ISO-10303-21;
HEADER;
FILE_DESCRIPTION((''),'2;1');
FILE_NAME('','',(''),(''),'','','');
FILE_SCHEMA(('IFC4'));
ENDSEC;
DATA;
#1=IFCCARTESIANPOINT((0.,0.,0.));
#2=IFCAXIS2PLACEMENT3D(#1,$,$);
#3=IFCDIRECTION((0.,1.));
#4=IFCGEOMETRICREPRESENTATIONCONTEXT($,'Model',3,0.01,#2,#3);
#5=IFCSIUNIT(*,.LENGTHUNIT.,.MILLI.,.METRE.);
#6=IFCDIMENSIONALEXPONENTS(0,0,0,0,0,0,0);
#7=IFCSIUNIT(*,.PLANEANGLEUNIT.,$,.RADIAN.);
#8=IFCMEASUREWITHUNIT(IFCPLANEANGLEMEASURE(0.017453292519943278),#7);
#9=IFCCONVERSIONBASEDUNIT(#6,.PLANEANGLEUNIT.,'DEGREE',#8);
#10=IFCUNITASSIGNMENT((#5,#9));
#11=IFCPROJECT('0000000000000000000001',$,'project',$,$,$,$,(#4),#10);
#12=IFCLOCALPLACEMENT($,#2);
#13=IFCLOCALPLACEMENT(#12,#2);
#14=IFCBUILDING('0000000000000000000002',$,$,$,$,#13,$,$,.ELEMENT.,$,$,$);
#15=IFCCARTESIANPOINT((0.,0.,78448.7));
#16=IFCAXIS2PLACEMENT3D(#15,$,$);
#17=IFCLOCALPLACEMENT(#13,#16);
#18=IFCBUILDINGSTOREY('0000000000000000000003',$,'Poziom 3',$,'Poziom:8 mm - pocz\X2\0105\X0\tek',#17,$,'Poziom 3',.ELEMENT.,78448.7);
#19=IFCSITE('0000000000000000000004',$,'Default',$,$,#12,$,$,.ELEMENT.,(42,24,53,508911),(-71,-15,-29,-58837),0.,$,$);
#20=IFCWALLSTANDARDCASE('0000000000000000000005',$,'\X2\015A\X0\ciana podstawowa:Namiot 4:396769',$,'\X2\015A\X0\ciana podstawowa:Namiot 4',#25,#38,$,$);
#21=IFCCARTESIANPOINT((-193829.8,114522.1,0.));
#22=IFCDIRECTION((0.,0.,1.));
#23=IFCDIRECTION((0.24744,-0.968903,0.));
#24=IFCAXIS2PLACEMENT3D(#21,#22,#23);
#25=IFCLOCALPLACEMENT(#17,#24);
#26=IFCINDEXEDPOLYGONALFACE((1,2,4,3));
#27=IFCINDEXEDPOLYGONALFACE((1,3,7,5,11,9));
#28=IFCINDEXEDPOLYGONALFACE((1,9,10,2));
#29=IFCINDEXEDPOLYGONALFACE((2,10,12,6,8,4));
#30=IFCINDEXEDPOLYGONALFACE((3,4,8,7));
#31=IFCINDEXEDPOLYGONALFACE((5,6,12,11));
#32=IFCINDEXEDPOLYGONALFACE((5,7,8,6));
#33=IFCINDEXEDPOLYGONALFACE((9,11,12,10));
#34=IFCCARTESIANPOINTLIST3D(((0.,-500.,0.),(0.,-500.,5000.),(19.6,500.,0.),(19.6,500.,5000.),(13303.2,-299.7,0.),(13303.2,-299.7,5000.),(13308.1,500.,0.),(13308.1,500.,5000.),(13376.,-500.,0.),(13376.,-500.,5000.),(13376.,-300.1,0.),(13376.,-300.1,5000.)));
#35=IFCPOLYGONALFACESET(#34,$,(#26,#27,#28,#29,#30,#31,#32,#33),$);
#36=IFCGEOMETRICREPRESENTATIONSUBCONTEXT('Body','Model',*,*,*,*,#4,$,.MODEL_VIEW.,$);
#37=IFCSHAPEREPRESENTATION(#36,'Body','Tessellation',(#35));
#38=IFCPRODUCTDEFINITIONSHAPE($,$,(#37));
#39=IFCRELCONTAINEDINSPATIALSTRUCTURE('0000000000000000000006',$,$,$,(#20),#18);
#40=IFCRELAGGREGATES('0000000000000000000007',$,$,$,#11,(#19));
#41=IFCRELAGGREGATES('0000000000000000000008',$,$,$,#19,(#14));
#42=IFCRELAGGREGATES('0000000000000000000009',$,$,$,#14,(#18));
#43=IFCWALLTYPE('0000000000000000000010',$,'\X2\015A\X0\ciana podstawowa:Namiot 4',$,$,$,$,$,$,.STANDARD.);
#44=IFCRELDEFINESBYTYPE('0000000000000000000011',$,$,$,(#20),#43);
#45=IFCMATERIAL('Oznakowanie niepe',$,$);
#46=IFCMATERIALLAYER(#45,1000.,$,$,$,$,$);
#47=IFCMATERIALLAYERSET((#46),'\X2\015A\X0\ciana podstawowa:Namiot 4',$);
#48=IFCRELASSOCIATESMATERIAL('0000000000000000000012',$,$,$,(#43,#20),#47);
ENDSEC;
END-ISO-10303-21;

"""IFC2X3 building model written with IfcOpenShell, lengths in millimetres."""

from ifc_helpers import new_model, entity, si_unit, converted_unit, direction, frame, origin, place, context, subcontext, project, spatial, polyline, outline, extrude, clip, bounded_halfspace, material, layer, layer_set, layer_usage, type_object, element, save


model = new_model("IFC2X3")

# Units and contexts
model_context = context("Model", 3, precision=0.01, world=origin(), true_north=direction((0.0, 1.0)))
body_context = subcontext(model_context, "Body", "Model", "MODEL_VIEW")
ifc_project = project(units=[si_unit("LENGTHUNIT", "METRE", prefix="MILLI"), converted_unit("PLANEANGLEUNIT", "DEGREE", entity("IfcPlaneAngleMeasure", 0.017453292519943278), si_unit("PLANEANGLEUNIT", "RADIAN"), dimensions=[0, 0, 0, 0, 0, 0, 0])], contexts=[model_context])

# Site, building, storey
site_placement = place(None, origin())
site = spatial("IfcSite", under=ifc_project, at=site_placement, Name="Default", CompositionType="ELEMENT", RefLatitude=(42, 24, 53, 508911), RefLongitude=(-71, -15, -29, -58837), RefElevation=0.0)
building_placement = place(site_placement, origin())
building = spatial("IfcBuilding", under=site, at=building_placement, CompositionType="ELEMENT")
storey_placement = place(building_placement, frame((0.0, 0.0, 78448.7)))
storey = spatial("IfcBuildingStorey", under=building, at=storey_placement, Name="Poziom 3", ObjectType="Poziom:8 mm - początek", LongName="Poziom 3", CompositionType="ELEMENT", Elevation=78448.7)

# Wall
ifc_material_1 = material(Name="Oznakowanie niepe")
ifc_layer_1 = layer(ifc_material_1, 1000.0)
ifc_layer_set_1 = layer_set([ifc_layer_1], Name="Ściana podstawowa:Namiot 4")
wall_type_1 = type_object("IfcWallType", Name="Ściana podstawowa:Namiot 4", PredefinedType="STANDARD", material=ifc_layer_set_1)
ifc_layer_usage_1 = layer_usage(ifc_layer_set_1, "AXIS2", "NEGATIVE", 500.0)
wall_1_placement = place(storey_placement, frame((-193829.8, 114522.1, 0.0), z_axis=(0.0, 0.0, 1.0), x_axis=(0.24744, -0.968903, 0.0)))
element("IfcWallStandardCase", 1, at=wall_1_placement, inside=storey, type_object=wall_type_1, material=ifc_layer_usage_1, Name="Ściana podstawowa:Namiot 4:396769", ObjectType="Ściana podstawowa:Namiot 4", context=body_context, shape_type="Clipping", body=[
    clip(clip(extrude(outline(polyline([(13376.0, -500.0), (13376.0, -300.1), (13303.2, -299.7), (13308.1, 500.0), (19.6, 500.0), (0.0, -500.0), (13376.0, -500.0)])), origin(), (0.0, 0.0, 1.0), 5000.0), bounded_halfspace(frame((13303.2, -299.7, 0.0), z_axis=(-0.0061, -0.999981, 0.0), x_axis=(0.999981, -0.0061, 0.0)), True, frame((13303.2, -299.7, 0.0), z_axis=(-0.0061, -0.999981, 0.0), x_axis=(0.999981, -0.0061, 0.0)), polyline([(0.0, 0.0), (72.8, 0.0), (72.8, 5000.0), (0.0, 5000.0), (0.0, 0.0)]))), bounded_halfspace(frame((13303.2, -299.7, 5000.0), z_axis=(-0.999981, 0.0061, 0.0), x_axis=(0.0061, 0.999981, 0.0)), True, frame((13303.2, -299.7, 5000.0), z_axis=(-0.999981, 0.0061, 0.0), x_axis=(0.0061, 0.999981, 0.0)), polyline([(0.0, 0.0), (799.7, 0.0), (799.7, 5000.0), (0.0, 5000.0), (0.0, 0.0)]))),
])

save(model, "model.ifc")
